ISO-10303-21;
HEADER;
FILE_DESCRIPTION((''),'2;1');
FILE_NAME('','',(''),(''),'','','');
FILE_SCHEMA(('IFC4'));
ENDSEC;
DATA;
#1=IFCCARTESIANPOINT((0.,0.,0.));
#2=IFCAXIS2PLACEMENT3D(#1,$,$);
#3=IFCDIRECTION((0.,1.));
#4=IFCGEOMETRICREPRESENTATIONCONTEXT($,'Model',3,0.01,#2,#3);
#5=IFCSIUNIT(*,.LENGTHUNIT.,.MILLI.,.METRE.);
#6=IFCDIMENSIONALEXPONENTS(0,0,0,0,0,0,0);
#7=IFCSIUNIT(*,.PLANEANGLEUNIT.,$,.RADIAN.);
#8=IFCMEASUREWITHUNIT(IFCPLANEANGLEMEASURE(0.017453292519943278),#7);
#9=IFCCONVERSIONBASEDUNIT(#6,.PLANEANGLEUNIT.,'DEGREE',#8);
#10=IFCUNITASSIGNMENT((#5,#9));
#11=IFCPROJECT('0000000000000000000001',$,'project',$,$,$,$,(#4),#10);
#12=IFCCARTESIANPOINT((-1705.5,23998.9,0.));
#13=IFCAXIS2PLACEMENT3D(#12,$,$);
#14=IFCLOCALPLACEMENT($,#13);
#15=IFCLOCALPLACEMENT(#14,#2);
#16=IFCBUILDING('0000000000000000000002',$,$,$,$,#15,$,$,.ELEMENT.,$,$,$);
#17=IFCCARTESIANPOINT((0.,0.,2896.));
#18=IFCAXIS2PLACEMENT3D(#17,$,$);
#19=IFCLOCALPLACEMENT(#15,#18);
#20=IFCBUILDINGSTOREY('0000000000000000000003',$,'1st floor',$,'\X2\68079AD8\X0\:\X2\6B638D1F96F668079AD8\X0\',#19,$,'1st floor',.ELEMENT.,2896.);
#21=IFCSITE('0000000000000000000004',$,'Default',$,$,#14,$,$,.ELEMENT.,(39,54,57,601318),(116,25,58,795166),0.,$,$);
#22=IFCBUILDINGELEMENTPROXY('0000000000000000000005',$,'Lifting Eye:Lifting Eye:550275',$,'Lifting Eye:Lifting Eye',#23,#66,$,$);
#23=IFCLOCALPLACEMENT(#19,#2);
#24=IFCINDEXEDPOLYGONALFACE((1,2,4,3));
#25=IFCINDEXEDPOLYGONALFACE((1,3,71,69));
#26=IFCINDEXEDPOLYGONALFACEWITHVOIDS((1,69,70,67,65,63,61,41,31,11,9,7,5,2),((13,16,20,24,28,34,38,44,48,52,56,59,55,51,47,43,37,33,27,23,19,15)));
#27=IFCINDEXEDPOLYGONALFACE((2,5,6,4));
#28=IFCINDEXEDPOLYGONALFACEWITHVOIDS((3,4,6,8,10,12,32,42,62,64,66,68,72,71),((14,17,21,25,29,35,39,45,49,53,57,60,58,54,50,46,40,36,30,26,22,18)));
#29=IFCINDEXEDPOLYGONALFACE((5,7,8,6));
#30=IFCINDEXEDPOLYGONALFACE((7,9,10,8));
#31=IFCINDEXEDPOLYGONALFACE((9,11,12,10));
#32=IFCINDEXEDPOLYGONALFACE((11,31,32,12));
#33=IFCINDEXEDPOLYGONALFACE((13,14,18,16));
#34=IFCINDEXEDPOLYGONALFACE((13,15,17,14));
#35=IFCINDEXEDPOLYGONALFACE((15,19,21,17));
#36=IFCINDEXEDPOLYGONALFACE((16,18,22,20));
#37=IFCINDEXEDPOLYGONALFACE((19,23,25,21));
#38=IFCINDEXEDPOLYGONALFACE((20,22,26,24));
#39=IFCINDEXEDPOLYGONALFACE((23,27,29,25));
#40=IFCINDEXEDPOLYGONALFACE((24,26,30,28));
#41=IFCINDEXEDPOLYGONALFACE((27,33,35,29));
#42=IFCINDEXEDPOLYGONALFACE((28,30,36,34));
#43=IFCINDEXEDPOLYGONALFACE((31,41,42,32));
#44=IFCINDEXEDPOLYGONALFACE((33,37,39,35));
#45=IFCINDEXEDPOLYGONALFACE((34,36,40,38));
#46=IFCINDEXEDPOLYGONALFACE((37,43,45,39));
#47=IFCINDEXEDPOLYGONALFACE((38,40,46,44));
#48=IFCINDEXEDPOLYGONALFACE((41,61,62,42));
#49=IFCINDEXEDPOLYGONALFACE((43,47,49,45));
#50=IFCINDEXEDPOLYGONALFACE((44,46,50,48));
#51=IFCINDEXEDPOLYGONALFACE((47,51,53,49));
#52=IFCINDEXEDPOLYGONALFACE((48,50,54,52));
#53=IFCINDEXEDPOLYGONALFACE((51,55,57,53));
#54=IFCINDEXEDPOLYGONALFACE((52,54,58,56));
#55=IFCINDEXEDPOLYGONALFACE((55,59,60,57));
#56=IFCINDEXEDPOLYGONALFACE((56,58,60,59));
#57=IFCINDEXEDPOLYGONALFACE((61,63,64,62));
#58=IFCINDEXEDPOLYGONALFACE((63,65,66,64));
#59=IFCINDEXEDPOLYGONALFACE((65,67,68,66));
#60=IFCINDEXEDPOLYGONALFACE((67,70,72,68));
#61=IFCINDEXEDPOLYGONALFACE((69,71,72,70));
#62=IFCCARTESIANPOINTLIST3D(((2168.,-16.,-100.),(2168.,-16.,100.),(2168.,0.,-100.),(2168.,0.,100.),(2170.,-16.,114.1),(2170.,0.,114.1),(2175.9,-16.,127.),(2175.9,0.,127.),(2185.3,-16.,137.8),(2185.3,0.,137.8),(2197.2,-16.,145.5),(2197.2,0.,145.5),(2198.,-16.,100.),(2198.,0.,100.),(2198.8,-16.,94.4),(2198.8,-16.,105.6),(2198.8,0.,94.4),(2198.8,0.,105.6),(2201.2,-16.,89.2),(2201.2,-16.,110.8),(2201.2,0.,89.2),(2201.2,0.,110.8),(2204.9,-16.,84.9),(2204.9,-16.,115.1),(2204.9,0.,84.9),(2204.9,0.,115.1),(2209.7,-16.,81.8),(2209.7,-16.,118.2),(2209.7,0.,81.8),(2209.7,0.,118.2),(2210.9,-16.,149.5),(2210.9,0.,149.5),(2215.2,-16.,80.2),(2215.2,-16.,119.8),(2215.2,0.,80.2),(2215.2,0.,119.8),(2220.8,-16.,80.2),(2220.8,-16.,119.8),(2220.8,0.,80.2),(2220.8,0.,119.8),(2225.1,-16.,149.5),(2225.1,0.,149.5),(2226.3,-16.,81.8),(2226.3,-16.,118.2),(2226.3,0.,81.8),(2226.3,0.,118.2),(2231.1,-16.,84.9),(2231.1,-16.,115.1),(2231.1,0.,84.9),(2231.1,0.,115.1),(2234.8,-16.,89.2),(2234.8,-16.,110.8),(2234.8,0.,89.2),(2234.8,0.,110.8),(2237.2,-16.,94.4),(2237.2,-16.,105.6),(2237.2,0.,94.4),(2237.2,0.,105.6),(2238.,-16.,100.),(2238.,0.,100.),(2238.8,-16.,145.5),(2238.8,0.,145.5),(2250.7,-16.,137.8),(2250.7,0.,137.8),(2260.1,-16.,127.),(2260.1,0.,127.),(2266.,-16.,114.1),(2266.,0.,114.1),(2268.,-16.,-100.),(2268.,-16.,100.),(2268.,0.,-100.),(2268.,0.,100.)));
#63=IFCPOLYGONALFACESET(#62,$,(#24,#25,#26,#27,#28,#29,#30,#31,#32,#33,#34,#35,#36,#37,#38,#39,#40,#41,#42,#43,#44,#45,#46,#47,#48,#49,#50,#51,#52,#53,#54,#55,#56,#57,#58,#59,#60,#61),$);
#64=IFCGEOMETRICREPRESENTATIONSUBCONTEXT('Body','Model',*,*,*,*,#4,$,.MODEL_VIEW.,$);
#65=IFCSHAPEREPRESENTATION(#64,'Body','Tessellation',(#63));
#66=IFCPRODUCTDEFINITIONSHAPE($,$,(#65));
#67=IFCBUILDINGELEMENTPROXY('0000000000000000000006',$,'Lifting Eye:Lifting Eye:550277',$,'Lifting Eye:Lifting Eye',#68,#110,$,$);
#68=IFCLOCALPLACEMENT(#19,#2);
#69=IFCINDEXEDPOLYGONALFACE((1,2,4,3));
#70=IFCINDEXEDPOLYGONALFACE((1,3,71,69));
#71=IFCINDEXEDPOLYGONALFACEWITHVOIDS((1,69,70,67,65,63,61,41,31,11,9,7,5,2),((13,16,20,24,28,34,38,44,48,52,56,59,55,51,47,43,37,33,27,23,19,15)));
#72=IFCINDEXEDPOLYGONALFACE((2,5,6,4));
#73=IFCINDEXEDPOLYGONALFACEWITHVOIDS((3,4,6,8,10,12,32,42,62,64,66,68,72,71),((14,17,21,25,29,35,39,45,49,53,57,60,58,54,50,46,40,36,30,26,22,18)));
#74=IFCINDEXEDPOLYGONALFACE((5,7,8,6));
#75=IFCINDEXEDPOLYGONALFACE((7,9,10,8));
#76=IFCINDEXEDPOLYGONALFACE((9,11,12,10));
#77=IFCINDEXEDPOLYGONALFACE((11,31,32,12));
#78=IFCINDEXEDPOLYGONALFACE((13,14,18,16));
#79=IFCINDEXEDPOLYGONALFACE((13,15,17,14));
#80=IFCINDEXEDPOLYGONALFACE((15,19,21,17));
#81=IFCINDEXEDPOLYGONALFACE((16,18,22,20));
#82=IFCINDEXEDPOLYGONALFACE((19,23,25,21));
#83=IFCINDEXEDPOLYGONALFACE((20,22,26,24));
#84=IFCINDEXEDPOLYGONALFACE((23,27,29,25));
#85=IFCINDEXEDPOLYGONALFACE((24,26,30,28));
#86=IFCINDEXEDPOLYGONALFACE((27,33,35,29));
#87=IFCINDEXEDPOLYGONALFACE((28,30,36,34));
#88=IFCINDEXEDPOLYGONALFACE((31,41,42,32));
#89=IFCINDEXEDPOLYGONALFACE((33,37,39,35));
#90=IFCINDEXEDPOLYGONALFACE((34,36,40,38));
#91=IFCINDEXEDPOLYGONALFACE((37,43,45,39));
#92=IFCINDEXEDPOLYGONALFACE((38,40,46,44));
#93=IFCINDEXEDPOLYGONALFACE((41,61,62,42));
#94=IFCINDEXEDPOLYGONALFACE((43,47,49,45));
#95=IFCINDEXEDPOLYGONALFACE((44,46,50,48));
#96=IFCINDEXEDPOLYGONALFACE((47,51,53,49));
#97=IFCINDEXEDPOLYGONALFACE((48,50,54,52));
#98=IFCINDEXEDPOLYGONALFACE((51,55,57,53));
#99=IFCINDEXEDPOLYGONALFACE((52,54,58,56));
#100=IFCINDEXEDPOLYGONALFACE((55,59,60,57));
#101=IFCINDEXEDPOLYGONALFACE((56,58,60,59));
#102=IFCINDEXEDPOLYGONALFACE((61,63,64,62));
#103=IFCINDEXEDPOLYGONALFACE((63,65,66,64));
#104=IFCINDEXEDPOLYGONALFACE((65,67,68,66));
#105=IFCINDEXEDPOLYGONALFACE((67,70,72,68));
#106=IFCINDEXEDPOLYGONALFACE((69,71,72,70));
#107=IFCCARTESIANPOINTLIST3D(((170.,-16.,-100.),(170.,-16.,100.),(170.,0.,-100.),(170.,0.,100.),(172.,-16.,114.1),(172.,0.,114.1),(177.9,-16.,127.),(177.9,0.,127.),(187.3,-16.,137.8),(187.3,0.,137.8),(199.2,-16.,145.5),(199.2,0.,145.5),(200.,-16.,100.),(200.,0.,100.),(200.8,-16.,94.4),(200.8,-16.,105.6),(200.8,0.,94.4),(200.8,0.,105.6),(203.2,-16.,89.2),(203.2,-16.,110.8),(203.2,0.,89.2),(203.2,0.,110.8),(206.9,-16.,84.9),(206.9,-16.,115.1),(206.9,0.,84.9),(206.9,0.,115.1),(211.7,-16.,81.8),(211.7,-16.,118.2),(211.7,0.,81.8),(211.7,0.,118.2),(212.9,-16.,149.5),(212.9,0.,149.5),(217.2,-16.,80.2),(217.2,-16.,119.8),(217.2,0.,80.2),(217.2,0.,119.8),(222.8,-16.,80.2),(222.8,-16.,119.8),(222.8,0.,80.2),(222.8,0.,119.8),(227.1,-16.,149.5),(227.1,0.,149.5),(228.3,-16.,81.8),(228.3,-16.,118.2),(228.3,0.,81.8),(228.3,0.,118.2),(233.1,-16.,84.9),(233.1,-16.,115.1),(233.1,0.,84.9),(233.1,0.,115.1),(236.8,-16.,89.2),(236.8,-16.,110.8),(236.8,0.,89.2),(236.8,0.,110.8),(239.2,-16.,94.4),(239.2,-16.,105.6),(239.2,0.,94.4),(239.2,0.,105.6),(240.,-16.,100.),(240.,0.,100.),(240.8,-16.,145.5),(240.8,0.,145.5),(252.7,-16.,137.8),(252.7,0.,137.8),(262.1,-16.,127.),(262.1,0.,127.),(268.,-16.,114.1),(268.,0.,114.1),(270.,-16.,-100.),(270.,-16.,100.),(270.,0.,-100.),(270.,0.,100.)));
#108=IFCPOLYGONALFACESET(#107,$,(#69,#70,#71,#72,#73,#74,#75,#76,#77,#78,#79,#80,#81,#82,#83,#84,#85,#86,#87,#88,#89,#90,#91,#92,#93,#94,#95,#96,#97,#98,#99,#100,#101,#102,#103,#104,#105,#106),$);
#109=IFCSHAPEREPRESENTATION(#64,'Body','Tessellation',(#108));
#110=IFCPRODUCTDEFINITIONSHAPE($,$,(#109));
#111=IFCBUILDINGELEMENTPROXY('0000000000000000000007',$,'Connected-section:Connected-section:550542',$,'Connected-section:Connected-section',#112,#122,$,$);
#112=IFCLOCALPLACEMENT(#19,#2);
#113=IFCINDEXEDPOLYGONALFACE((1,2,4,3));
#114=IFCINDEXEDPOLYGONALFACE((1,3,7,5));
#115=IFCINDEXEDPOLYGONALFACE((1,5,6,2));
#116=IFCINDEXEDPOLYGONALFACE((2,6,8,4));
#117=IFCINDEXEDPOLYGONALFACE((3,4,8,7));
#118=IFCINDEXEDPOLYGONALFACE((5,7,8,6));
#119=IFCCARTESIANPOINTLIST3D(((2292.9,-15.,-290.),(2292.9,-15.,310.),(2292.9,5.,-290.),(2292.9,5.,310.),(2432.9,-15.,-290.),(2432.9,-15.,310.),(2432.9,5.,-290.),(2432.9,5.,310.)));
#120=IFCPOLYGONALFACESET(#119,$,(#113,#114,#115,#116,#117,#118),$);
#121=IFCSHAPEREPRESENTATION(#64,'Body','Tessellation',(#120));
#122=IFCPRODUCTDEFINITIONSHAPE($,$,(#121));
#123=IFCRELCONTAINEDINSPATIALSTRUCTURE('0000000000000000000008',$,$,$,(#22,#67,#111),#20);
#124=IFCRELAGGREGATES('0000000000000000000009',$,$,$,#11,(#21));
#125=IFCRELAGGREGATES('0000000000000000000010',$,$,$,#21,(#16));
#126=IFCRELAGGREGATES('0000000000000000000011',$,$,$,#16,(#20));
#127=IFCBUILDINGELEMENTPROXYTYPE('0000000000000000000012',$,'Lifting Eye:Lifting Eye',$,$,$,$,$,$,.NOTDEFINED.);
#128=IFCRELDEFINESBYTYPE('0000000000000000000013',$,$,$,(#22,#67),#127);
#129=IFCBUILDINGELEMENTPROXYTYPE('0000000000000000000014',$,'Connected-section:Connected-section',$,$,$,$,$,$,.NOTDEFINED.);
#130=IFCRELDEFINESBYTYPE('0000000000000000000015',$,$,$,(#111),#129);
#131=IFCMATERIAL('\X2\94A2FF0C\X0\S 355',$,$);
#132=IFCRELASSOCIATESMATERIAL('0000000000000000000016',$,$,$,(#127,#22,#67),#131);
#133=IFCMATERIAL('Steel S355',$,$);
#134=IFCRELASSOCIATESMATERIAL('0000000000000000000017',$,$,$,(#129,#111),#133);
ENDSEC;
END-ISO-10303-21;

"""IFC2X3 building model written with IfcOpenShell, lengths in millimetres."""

from ifc_helpers import new_model, entity, si_unit, converted_unit, direction, frame, frame_2d, origin, place, context, subcontext, project, spatial, polyline, circle_curve, parameter, trimmed, segment, composite_curve, rectangle, outline, extrude, source, transform, mapped, material, type_object, type_shapes, element, save


model = new_model("IFC2X3")

# Units and contexts
model_context = context("Model", 3, precision=0.01, world=origin(), true_north=direction((0.0, 1.0)))
body_context = subcontext(model_context, "Body", "Model", "MODEL_VIEW")
ifc_project = project(units=[si_unit("LENGTHUNIT", "METRE", prefix="MILLI"), converted_unit("PLANEANGLEUNIT", "DEGREE", entity("IfcPlaneAngleMeasure", 0.017453292519943278), si_unit("PLANEANGLEUNIT", "RADIAN"), dimensions=[0, 0, 0, 0, 0, 0, 0])], contexts=[model_context])

# Site, building, storey
site_placement = place(None, frame((-1705.5, 23998.9, 0.0)))
site = spatial("IfcSite", under=ifc_project, at=site_placement, Name="Default", CompositionType="ELEMENT", RefLatitude=(39, 54, 57, 601318), RefLongitude=(116, 25, 58, 795166), RefElevation=0.0)
building_placement = place(site_placement, origin())
building = spatial("IfcBuilding", under=site, at=building_placement, CompositionType="ELEMENT")
storey_placement = place(building_placement, frame((0.0, 0.0, 2896.0)))
storey = spatial("IfcBuildingStorey", under=building, at=storey_placement, Name="1st floor", ObjectType="标高:正负零标高", LongName="1st floor", CompositionType="ELEMENT", Elevation=2896.0)

# Shared definitions
ifc_material_1 = material(Name="Steel S355")

# Building element proxies
ifc_material_2 = material(Name="钢，S 355")
building_element_proxy_type_1 = type_object("IfcBuildingElementProxyType", Name="Lifting Eye:Lifting Eye", PredefinedType="NOTDEFINED", material=ifc_material_2)
shared_shape_1 = source(origin(), body_context, "Body", "SweptSolid", [
    extrude(outline(composite_curve([segment(polyline([(-100.0, -50.0), (100.0, -50.0)]), True, "CONTINUOUS"), segment(polyline([(100.0, -50.0), (100.0, 50.0)]), True, "CONTINUOUS"), segment(polyline([(100.0, 50.0), (-100.0, 50.0)]), True, "CONTINUOUS"), segment(trimmed(circle_curve(frame_2d((-100.0, 0.0), x_axis=(0.0, -1.0)), 50.0), [parameter(180.0)], [parameter(0.0)], True, "PARAMETER"), True, "CONTINUOUS")], self_intersect=False), holes=[composite_curve([segment(trimmed(circle_curve(frame_2d((-100.0, 0.0), x_axis=(0.0, -1.0)), 20.0), [parameter(180.0)], [parameter(360.0)], True, "PARAMETER"), False, "CONTINUOUS"), segment(trimmed(circle_curve(frame_2d((-100.0, 0.0), x_axis=(0.0, -1.0)), 20.0), [parameter(0.0)], [parameter(180.0)], True, "PARAMETER"), False, "CONTINUOUS")], self_intersect=False)]), frame((0.0, 17.0, -17.0), z_axis=(0.0, 1.0, 0.0), x_axis=(0.0, 0.0, -1.0)), (0.0, 0.0, 1.0), 16.0),
])
type_shapes(building_element_proxy_type_1, [shared_shape_1])
for number, where, name in (
    (1, (2218.0, -33.0, 17.0), "Lifting Eye:Lifting Eye:550275"),
    (2, (220.0, -33.0, 17.0), "Lifting Eye:Lifting Eye:550277"),
):
    element("IfcBuildingElementProxy", number, at=place(storey_placement, frame(where)), inside=storey, type_object=building_element_proxy_type_1, material=ifc_material_2, Name=name, ObjectType="Lifting Eye:Lifting Eye", context=body_context, shape_type="MappedRepresentation", body=[
        mapped(shared_shape_1, transform((0.0, 0.0, 0.0), scale=1.0)),
    ])
building_element_proxy_type_2 = type_object("IfcBuildingElementProxyType", Name="Connected-section:Connected-section", PredefinedType="NOTDEFINED", material=ifc_material_1)
shared_shape_2 = source(origin(), body_context, "Body", "SweptSolid", [
    extrude(rectangle(XDim=20.0, YDim=140.0, at=frame_2d((0.0, 0.0), x_axis=(1.0, 0.0))), frame((70.0, 10.0, 0.0), z_axis=(0.0, 0.0, 1.0), x_axis=(0.0, 1.0, 0.0)), (0.0, 0.0, 1.0), 600.0),
])
type_shapes(building_element_proxy_type_2, [shared_shape_2])
proxy_placement = place(storey_placement, frame((2292.9, -15.0, -290.0)))
element("IfcBuildingElementProxy", 3, at=proxy_placement, inside=storey, type_object=building_element_proxy_type_2, material=ifc_material_1, Name="Connected-section:Connected-section:550542", ObjectType="Connected-section:Connected-section", context=body_context, shape_type="MappedRepresentation", body=[
    mapped(shared_shape_2, transform((0.0, 0.0, 0.0), scale=1.0)),
])

save(model, "model.ifc")
